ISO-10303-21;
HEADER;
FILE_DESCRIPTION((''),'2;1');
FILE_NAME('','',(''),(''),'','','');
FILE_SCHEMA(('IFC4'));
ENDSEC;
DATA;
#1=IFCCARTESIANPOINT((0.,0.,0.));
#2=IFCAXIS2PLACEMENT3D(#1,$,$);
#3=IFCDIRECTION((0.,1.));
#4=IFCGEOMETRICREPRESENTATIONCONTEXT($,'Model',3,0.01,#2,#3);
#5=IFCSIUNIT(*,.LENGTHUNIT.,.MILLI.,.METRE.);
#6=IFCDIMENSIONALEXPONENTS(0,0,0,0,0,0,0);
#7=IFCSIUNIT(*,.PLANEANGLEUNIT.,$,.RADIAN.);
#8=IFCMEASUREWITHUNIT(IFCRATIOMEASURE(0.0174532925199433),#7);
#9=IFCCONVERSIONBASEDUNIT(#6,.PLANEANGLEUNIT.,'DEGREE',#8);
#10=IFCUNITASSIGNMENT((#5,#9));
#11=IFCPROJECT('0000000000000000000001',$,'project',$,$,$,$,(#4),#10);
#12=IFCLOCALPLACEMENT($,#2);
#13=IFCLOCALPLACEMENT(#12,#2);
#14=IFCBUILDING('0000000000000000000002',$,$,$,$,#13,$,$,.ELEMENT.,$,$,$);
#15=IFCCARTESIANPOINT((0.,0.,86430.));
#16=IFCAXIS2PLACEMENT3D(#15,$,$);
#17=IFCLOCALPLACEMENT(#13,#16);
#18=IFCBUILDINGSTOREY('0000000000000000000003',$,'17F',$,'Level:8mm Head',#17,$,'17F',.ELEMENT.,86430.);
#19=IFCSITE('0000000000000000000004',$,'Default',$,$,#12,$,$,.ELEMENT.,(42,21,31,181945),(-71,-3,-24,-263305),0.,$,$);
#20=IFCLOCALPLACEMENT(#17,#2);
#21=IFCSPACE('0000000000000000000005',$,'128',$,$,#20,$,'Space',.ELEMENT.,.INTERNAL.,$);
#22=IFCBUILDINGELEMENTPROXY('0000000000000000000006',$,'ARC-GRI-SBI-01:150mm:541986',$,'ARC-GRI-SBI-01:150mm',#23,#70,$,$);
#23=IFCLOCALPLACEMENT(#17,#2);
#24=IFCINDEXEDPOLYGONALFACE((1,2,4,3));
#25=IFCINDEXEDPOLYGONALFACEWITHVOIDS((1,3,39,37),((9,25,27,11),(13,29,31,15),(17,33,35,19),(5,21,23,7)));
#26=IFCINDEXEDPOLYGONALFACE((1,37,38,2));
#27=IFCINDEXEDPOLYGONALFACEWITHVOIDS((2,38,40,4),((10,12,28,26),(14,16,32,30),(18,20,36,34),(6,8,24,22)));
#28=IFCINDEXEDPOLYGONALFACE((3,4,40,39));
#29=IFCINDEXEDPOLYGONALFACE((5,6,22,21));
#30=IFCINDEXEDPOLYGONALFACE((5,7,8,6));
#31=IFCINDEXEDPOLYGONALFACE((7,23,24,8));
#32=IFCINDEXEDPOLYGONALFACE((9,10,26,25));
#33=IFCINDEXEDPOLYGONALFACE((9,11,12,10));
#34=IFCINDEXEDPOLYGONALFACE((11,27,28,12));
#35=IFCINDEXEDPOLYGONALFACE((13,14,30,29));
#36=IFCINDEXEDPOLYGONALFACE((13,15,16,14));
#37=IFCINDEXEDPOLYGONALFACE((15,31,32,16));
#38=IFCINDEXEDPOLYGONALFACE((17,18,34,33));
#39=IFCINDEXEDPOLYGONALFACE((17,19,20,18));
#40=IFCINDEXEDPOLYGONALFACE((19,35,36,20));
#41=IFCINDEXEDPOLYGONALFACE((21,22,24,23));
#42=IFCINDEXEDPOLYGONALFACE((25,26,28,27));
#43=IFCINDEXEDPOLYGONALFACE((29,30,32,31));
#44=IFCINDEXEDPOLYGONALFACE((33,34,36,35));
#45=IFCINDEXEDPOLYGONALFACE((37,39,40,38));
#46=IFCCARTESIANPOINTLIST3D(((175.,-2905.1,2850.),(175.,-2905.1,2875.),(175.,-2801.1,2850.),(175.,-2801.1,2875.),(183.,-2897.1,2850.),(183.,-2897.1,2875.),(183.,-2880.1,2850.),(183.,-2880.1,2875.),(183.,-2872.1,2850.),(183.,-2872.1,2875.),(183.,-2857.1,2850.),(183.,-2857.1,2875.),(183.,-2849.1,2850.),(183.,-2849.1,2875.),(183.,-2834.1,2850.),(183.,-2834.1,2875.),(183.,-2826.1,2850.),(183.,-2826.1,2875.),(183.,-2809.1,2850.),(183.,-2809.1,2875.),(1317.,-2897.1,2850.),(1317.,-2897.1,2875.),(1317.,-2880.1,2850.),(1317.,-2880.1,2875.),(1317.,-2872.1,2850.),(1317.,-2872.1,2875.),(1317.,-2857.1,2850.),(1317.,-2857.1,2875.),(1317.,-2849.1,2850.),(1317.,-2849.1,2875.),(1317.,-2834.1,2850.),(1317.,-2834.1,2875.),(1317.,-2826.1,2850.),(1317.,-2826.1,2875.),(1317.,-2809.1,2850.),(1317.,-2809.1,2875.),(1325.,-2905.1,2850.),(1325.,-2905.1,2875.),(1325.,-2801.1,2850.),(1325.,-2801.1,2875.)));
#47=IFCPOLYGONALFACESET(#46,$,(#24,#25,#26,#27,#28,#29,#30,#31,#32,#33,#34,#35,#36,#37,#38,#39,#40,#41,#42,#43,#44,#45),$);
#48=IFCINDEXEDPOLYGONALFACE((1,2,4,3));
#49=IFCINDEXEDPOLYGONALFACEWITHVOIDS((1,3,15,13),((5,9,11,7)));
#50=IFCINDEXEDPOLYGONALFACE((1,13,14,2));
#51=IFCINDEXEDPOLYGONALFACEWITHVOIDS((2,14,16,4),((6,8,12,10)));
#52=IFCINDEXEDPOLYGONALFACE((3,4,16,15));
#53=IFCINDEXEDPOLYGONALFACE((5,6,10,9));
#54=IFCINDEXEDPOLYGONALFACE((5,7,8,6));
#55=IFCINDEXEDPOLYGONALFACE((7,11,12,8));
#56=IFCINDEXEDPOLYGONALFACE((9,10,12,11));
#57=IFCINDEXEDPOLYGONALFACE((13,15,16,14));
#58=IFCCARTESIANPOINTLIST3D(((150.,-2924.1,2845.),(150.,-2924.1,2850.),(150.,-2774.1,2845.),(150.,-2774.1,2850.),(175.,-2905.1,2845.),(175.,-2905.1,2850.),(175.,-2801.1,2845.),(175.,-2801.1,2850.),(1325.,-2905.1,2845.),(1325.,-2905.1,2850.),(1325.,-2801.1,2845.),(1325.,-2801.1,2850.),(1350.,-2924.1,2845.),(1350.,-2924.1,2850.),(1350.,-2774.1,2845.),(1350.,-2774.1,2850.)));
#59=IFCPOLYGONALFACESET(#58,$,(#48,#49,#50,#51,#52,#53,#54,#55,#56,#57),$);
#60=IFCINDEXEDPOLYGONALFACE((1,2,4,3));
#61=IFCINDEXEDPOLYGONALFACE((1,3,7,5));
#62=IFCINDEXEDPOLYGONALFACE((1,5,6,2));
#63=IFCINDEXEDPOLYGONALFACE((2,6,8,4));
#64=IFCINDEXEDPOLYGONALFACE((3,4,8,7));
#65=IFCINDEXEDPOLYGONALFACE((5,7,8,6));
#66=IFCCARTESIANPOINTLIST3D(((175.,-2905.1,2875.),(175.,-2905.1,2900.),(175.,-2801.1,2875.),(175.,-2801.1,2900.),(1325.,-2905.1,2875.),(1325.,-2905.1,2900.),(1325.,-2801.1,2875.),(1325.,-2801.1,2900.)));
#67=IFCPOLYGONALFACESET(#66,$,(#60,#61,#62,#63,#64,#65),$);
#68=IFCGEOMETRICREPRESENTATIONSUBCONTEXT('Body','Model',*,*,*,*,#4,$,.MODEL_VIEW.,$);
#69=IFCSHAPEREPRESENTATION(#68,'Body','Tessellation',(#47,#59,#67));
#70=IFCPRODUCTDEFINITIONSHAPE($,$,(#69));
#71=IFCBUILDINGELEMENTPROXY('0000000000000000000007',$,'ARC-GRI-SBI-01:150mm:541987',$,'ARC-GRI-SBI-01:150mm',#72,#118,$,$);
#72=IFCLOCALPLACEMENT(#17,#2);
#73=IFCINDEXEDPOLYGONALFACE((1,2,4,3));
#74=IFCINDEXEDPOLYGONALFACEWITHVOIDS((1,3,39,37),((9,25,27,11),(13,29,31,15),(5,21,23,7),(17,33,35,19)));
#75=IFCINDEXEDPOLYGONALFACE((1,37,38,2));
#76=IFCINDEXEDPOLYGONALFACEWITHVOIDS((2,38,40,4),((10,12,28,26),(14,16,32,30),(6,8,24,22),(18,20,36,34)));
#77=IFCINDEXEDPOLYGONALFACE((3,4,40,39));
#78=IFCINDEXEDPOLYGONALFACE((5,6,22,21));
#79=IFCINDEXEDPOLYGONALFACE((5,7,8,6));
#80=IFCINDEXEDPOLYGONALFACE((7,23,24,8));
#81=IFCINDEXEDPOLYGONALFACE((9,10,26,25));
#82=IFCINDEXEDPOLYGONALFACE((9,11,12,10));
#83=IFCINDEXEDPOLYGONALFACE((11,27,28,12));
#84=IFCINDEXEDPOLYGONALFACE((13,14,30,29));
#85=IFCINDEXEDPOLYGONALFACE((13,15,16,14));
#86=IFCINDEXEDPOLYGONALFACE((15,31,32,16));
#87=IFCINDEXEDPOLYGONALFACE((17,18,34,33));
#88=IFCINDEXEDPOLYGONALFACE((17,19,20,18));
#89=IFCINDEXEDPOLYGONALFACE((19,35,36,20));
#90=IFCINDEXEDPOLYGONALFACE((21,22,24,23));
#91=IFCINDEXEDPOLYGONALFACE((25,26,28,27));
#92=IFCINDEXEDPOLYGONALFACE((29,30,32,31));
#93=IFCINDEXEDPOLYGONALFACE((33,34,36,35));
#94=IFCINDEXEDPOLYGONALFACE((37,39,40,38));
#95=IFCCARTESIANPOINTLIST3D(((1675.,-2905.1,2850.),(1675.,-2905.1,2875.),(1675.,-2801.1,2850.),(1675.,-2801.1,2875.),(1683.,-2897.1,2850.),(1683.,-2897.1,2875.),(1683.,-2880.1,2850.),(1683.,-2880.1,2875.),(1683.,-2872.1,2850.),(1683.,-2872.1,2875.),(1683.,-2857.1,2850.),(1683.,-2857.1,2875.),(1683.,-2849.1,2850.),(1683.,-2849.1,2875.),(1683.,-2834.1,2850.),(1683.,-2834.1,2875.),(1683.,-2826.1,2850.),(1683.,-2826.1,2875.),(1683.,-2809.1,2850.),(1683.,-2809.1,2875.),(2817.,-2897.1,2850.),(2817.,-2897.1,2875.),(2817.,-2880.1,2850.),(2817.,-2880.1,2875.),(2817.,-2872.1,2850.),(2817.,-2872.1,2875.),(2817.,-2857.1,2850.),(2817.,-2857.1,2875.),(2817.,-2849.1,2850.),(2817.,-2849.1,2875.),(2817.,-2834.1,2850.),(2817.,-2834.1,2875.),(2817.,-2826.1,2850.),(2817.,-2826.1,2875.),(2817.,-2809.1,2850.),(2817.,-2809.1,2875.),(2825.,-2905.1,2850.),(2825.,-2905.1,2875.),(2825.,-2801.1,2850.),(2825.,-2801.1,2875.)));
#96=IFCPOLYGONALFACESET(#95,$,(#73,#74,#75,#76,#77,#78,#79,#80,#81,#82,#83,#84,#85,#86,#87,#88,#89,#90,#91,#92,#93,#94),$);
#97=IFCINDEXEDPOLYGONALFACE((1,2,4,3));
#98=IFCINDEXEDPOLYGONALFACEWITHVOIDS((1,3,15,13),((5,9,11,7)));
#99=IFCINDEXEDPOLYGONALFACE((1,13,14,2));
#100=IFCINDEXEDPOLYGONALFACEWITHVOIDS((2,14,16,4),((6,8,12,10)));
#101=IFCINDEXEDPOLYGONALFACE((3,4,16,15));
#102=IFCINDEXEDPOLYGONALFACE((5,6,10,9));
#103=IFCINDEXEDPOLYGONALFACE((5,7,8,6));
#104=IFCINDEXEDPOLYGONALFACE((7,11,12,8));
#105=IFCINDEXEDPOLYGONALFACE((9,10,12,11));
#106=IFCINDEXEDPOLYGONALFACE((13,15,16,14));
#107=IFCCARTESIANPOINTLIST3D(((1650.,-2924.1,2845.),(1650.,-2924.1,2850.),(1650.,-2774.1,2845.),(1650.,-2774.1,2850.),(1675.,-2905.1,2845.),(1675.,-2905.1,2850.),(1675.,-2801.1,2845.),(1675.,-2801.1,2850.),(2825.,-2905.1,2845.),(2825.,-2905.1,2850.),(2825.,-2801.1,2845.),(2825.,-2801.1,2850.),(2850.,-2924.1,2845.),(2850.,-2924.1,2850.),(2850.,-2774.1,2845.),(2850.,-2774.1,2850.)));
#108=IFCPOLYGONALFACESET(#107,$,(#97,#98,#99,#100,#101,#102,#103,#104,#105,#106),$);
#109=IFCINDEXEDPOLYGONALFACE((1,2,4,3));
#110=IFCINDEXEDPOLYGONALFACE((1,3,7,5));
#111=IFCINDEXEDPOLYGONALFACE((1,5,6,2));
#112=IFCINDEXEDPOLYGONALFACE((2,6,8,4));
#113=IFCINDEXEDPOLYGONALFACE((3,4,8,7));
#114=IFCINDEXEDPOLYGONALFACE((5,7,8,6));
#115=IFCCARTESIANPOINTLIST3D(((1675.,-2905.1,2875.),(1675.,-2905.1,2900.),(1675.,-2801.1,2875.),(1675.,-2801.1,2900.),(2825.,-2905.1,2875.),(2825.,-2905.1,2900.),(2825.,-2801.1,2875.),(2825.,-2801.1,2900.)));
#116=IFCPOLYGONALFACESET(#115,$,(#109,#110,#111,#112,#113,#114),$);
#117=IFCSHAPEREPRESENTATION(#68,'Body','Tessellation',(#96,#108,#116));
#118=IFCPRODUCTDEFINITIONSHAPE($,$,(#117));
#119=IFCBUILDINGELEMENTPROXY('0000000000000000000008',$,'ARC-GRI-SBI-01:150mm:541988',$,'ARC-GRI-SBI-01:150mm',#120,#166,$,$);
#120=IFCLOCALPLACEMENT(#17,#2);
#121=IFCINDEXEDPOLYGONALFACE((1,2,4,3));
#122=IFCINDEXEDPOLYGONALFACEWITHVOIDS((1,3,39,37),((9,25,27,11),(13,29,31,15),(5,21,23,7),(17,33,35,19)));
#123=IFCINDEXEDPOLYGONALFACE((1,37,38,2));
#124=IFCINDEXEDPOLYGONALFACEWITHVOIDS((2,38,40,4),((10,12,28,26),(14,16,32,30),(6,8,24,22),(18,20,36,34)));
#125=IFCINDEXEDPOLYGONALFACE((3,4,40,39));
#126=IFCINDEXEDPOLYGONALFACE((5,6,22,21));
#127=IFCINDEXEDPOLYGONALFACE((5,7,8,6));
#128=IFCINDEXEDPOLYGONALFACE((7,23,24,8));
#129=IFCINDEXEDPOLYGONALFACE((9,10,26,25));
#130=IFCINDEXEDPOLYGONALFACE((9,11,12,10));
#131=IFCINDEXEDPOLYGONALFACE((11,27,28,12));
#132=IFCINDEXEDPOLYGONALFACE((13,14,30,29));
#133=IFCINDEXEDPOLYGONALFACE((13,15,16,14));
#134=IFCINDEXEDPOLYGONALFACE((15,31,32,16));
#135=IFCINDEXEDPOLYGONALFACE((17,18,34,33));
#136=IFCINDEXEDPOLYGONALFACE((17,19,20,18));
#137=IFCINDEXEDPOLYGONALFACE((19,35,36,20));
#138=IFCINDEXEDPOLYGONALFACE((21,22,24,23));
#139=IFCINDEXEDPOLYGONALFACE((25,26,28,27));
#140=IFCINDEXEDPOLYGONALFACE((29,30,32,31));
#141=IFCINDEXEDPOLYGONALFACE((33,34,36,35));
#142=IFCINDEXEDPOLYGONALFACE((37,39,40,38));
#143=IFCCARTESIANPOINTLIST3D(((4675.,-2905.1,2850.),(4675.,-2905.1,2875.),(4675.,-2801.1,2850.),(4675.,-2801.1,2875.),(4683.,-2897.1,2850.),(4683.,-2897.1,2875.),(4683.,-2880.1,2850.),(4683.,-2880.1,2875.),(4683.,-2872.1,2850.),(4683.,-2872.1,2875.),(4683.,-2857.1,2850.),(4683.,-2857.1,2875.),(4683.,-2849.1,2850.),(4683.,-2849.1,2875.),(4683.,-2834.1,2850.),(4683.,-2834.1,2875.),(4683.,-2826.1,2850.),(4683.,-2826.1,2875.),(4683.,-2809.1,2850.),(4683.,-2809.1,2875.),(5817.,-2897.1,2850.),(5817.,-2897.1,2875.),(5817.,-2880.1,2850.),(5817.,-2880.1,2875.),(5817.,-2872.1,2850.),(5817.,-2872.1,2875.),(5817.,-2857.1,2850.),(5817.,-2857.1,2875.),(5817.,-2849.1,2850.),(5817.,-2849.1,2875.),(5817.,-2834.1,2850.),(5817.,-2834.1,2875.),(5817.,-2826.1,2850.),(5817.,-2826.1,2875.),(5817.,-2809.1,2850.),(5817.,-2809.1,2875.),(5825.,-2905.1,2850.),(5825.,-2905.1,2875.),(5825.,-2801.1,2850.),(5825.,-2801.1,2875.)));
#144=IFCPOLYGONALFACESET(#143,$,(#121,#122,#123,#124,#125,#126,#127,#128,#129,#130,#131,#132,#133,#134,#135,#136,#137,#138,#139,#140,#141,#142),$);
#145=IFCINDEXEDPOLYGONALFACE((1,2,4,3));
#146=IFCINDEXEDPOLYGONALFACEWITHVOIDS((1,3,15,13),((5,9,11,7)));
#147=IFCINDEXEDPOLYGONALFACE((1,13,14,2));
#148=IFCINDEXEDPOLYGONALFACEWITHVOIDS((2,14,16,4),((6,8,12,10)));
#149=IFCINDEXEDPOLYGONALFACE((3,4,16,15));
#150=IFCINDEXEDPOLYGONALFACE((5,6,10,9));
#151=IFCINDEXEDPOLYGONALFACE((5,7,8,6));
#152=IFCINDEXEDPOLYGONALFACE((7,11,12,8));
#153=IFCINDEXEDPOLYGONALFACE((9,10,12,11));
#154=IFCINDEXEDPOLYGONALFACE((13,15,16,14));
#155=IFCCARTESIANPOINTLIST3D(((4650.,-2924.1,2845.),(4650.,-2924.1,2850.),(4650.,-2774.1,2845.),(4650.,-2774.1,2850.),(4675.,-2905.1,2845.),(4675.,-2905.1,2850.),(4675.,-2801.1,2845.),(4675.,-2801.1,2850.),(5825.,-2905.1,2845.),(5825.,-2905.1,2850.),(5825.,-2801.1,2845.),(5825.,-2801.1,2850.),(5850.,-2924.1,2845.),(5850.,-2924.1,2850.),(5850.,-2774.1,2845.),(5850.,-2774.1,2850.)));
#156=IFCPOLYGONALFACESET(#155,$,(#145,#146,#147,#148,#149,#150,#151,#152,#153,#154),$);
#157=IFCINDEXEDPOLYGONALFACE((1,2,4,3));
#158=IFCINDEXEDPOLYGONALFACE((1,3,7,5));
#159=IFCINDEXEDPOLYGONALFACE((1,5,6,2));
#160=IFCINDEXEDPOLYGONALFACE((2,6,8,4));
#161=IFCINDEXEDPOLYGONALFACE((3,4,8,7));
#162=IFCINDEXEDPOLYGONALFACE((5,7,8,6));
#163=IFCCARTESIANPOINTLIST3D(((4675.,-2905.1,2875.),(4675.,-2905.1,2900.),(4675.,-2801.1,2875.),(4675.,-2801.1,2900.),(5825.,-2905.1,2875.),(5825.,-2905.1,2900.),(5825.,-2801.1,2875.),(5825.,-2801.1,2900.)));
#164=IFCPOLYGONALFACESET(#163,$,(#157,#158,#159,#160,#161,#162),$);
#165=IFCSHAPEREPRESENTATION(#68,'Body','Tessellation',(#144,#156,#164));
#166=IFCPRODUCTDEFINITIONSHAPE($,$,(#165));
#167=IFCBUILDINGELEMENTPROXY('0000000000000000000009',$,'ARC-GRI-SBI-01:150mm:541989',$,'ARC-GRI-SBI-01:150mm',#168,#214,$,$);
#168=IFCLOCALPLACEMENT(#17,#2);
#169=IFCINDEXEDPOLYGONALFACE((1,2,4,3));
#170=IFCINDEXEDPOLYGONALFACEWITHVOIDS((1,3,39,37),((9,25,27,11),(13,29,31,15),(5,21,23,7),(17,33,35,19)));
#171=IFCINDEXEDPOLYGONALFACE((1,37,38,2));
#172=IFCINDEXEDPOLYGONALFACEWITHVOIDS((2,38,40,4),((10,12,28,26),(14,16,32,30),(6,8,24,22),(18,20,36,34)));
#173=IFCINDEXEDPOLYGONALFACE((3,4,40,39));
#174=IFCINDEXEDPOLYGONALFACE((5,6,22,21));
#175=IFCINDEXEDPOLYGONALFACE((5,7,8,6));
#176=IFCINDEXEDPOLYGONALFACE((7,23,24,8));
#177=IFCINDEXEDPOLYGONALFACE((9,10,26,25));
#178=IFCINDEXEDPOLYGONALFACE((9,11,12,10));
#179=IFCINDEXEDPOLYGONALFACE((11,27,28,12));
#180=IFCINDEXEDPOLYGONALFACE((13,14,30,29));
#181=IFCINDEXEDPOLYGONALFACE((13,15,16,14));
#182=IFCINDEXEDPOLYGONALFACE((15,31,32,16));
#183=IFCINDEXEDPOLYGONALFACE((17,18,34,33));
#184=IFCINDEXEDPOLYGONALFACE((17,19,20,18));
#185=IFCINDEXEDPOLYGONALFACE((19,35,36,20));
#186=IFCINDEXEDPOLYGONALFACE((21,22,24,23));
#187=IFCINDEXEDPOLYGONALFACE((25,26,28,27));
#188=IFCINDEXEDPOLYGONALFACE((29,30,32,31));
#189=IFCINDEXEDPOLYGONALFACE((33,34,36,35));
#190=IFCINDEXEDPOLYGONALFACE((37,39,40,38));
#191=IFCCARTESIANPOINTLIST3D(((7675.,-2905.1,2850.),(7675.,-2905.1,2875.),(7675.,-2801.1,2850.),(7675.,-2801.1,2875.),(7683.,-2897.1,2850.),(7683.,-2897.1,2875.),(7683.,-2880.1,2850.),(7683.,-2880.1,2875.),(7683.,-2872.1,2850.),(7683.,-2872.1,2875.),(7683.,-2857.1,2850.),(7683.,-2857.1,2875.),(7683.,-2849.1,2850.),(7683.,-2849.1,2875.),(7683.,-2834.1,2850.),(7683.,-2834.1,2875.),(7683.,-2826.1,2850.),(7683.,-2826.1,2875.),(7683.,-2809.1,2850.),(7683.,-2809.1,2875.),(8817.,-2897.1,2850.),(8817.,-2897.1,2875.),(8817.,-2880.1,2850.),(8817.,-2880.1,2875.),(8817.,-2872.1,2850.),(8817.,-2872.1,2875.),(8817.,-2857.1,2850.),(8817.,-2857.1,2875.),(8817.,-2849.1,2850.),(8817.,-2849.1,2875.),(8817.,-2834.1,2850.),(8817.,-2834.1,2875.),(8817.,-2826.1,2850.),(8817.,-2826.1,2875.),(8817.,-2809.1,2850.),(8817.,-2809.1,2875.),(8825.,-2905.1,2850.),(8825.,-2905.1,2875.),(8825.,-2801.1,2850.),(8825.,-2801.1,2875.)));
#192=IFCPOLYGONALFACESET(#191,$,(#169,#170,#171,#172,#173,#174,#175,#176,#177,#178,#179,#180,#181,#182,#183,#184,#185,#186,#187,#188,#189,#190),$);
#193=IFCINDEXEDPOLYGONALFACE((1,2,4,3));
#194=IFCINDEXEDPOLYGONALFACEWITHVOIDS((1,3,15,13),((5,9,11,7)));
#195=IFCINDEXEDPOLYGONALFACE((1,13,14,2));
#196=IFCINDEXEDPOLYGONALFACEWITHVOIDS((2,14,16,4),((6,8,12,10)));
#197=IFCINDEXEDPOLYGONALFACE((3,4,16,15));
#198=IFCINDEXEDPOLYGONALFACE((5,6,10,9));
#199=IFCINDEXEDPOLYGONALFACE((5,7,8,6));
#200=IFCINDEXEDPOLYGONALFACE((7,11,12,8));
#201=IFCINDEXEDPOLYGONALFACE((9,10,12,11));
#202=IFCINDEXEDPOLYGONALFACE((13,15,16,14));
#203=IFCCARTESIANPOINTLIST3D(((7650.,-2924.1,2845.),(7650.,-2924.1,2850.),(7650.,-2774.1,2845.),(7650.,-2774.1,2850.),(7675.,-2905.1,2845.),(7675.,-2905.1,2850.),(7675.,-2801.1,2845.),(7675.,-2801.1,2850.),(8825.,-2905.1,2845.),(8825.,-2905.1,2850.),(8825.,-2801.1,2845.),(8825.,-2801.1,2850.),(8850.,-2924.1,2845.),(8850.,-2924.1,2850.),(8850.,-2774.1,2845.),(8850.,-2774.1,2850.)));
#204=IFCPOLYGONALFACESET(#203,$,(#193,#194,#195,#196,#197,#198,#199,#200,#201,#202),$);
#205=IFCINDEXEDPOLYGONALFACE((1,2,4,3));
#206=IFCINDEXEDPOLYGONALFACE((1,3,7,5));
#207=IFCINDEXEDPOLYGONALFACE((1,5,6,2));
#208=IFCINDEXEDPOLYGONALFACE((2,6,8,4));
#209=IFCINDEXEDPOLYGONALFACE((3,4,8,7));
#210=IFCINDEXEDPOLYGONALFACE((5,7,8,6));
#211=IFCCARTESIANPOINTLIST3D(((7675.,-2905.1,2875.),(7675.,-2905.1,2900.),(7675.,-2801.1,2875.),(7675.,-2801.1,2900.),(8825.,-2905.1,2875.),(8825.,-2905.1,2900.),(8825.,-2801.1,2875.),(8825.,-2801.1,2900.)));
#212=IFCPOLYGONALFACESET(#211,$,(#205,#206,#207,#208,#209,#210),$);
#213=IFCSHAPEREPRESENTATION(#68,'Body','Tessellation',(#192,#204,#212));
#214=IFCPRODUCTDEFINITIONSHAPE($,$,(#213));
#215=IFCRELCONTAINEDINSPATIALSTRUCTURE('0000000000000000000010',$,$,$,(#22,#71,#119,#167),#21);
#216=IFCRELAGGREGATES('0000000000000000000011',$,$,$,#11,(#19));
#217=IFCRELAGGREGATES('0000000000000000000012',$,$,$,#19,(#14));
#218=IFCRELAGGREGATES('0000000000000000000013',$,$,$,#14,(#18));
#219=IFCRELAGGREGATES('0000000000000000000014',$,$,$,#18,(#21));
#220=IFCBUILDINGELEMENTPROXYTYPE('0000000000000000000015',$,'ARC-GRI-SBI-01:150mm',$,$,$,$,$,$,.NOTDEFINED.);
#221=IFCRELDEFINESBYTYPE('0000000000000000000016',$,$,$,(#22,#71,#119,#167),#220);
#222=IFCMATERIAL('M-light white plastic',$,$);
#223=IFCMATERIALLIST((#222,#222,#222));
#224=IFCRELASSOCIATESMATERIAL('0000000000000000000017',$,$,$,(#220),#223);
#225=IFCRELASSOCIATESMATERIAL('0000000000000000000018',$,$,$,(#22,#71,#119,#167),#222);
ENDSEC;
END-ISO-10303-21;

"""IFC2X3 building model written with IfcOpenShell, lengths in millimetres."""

from ifc_helpers import new_model, entity, si_unit, converted_unit, direction, frame, origin, origin_2d_with_axis, place, context, subcontext, project, spatial, polyline, rectangle, outline, extrude, source, transform, mapped, material, material_list, type_object, type_shapes, element, save


model = new_model("IFC2X3")

# Units and contexts
model_context = context("Model", 3, precision=0.01, world=origin(), true_north=direction((0.0, 1.0)))
body_context = subcontext(model_context, "Body", "Model", "MODEL_VIEW")
ifc_project = project(units=[si_unit("LENGTHUNIT", "METRE", prefix="MILLI"), converted_unit("PLANEANGLEUNIT", "DEGREE", entity("IfcRatioMeasure", 0.0174532925199433), si_unit("PLANEANGLEUNIT", "RADIAN"), dimensions=[0, 0, 0, 0, 0, 0, 0])], contexts=[model_context])

# Site, building, storey
site_placement = place(None, origin())
site = spatial("IfcSite", under=ifc_project, at=site_placement, Name="Default", CompositionType="ELEMENT", RefLatitude=(42, 21, 31, 181945), RefLongitude=(-71, -3, -24, -263305), RefElevation=0.0)
building_placement = place(site_placement, origin())
building = spatial("IfcBuilding", under=site, at=building_placement, CompositionType="ELEMENT")
storey_placement = place(building_placement, frame((0.0, 0.0, 86430.0)))
storey = spatial("IfcBuildingStorey", under=building, at=storey_placement, Name="17F", ObjectType="Level:8mm Head", LongName="17F", CompositionType="ELEMENT", Elevation=86430.0)

# Shared definitions
space_placement = place(storey_placement, origin())
space = spatial("IfcSpace", under=storey, at=space_placement, Name="128", LongName="Space", CompositionType="ELEMENT", InteriorOrExteriorSpace="INTERNAL")

# Building element proxies
ifc_material_1 = material(Name="M-light white plastic")
ifc_material_list = material_list([ifc_material_1, ifc_material_1, ifc_material_1])
building_element_proxy_type = type_object("IfcBuildingElementProxyType", Name="ARC-GRI-SBI-01:150mm", PredefinedType="NOTDEFINED", material=ifc_material_list)
shared_shape = source(origin(), body_context, "Body", "SweptSolid", [
    extrude(outline(polyline([(-575.0, -52.0), (575.0, -52.0), (575.0, 52.0), (-575.0, 52.0), (-575.0, -52.0)]), holes=[polyline([(-567.0, -44.0), (-567.0, -27.0), (567.0, -27.0), (567.0, -44.0), (-567.0, -44.0)]), polyline([(567.0, -4.0), (567.0, -19.0), (-567.0, -19.0), (-567.0, -4.0), (567.0, -4.0)]), polyline([(-567.0, 44.0), (567.0, 44.0), (567.0, 27.0), (-567.0, 27.0), (-567.0, 44.0)]), polyline([(567.0, 4.0), (-567.0, 4.0), (-567.0, 19.0), (567.0, 19.0), (567.0, 4.0)])]), frame((425.0, 4.0, 4000.0), z_axis=(0.0, 0.0, 1.0), x_axis=(-1.0, 0.0, 0.0)), (0.0, 0.0, 1.0), 25.0),
    extrude(outline(polyline([(-600.0, -75.0), (600.0, -75.0), (600.0, 75.0), (-600.0, 75.0), (-600.0, -75.0)]), holes=[polyline([(-575.0, -56.0), (-575.0, 48.0), (575.0, 48.0), (575.0, -56.0), (-575.0, -56.0)])]), frame((425.0, 0.0, 3995.0), z_axis=(0.0, 0.0, 1.0), x_axis=(-1.0, 0.0, 0.0)), (0.0, 0.0, 1.0), 5.0),
    extrude(rectangle(XDim=1150.0, YDim=104.0, at=origin_2d_with_axis()), frame((425.0, 4.0, 4025.0), z_axis=(0.0, 0.0, 1.0), x_axis=(-1.0, 0.0, 0.0)), (0.0, 0.0, 1.0), 25.0),
])
type_shapes(building_element_proxy_type, [shared_shape])
for number, where, z_axis, x_axis, name in (
    (1, (1175.0, -2849.1, -1150.0), (0.0, 0.0, 1.0), (-1.0, 0.0, 0.0), "ARC-GRI-SBI-01:150mm:541986"),
    (2, (2675.0, -2849.1, -1150.0), (0.0, 0.0, 1.0), (-1.0, 0.0, 0.0), "ARC-GRI-SBI-01:150mm:541987"),
    (3, (5675.0, -2849.1, -1150.0), (0.0, 0.0, 1.0), (-1.0, 0.0, 0.0), "ARC-GRI-SBI-01:150mm:541988"),
    (4, (8675.0, -2849.1, -1150.0), (0.0, 0.0, 1.0), (-1.0, 0.0, 0.0), "ARC-GRI-SBI-01:150mm:541989"),
):
    element("IfcBuildingElementProxy", number, at=place(space_placement, frame(where, z_axis=z_axis, x_axis=x_axis)), inside=space, type_object=building_element_proxy_type, material=ifc_material_1, Name=name, ObjectType="ARC-GRI-SBI-01:150mm", context=body_context, shape_type="MappedRepresentation", body=[
        mapped(shared_shape, transform((0.0, 0.0, 0.0), scale=1.0)),
    ])

save(model, "model.ifc")
